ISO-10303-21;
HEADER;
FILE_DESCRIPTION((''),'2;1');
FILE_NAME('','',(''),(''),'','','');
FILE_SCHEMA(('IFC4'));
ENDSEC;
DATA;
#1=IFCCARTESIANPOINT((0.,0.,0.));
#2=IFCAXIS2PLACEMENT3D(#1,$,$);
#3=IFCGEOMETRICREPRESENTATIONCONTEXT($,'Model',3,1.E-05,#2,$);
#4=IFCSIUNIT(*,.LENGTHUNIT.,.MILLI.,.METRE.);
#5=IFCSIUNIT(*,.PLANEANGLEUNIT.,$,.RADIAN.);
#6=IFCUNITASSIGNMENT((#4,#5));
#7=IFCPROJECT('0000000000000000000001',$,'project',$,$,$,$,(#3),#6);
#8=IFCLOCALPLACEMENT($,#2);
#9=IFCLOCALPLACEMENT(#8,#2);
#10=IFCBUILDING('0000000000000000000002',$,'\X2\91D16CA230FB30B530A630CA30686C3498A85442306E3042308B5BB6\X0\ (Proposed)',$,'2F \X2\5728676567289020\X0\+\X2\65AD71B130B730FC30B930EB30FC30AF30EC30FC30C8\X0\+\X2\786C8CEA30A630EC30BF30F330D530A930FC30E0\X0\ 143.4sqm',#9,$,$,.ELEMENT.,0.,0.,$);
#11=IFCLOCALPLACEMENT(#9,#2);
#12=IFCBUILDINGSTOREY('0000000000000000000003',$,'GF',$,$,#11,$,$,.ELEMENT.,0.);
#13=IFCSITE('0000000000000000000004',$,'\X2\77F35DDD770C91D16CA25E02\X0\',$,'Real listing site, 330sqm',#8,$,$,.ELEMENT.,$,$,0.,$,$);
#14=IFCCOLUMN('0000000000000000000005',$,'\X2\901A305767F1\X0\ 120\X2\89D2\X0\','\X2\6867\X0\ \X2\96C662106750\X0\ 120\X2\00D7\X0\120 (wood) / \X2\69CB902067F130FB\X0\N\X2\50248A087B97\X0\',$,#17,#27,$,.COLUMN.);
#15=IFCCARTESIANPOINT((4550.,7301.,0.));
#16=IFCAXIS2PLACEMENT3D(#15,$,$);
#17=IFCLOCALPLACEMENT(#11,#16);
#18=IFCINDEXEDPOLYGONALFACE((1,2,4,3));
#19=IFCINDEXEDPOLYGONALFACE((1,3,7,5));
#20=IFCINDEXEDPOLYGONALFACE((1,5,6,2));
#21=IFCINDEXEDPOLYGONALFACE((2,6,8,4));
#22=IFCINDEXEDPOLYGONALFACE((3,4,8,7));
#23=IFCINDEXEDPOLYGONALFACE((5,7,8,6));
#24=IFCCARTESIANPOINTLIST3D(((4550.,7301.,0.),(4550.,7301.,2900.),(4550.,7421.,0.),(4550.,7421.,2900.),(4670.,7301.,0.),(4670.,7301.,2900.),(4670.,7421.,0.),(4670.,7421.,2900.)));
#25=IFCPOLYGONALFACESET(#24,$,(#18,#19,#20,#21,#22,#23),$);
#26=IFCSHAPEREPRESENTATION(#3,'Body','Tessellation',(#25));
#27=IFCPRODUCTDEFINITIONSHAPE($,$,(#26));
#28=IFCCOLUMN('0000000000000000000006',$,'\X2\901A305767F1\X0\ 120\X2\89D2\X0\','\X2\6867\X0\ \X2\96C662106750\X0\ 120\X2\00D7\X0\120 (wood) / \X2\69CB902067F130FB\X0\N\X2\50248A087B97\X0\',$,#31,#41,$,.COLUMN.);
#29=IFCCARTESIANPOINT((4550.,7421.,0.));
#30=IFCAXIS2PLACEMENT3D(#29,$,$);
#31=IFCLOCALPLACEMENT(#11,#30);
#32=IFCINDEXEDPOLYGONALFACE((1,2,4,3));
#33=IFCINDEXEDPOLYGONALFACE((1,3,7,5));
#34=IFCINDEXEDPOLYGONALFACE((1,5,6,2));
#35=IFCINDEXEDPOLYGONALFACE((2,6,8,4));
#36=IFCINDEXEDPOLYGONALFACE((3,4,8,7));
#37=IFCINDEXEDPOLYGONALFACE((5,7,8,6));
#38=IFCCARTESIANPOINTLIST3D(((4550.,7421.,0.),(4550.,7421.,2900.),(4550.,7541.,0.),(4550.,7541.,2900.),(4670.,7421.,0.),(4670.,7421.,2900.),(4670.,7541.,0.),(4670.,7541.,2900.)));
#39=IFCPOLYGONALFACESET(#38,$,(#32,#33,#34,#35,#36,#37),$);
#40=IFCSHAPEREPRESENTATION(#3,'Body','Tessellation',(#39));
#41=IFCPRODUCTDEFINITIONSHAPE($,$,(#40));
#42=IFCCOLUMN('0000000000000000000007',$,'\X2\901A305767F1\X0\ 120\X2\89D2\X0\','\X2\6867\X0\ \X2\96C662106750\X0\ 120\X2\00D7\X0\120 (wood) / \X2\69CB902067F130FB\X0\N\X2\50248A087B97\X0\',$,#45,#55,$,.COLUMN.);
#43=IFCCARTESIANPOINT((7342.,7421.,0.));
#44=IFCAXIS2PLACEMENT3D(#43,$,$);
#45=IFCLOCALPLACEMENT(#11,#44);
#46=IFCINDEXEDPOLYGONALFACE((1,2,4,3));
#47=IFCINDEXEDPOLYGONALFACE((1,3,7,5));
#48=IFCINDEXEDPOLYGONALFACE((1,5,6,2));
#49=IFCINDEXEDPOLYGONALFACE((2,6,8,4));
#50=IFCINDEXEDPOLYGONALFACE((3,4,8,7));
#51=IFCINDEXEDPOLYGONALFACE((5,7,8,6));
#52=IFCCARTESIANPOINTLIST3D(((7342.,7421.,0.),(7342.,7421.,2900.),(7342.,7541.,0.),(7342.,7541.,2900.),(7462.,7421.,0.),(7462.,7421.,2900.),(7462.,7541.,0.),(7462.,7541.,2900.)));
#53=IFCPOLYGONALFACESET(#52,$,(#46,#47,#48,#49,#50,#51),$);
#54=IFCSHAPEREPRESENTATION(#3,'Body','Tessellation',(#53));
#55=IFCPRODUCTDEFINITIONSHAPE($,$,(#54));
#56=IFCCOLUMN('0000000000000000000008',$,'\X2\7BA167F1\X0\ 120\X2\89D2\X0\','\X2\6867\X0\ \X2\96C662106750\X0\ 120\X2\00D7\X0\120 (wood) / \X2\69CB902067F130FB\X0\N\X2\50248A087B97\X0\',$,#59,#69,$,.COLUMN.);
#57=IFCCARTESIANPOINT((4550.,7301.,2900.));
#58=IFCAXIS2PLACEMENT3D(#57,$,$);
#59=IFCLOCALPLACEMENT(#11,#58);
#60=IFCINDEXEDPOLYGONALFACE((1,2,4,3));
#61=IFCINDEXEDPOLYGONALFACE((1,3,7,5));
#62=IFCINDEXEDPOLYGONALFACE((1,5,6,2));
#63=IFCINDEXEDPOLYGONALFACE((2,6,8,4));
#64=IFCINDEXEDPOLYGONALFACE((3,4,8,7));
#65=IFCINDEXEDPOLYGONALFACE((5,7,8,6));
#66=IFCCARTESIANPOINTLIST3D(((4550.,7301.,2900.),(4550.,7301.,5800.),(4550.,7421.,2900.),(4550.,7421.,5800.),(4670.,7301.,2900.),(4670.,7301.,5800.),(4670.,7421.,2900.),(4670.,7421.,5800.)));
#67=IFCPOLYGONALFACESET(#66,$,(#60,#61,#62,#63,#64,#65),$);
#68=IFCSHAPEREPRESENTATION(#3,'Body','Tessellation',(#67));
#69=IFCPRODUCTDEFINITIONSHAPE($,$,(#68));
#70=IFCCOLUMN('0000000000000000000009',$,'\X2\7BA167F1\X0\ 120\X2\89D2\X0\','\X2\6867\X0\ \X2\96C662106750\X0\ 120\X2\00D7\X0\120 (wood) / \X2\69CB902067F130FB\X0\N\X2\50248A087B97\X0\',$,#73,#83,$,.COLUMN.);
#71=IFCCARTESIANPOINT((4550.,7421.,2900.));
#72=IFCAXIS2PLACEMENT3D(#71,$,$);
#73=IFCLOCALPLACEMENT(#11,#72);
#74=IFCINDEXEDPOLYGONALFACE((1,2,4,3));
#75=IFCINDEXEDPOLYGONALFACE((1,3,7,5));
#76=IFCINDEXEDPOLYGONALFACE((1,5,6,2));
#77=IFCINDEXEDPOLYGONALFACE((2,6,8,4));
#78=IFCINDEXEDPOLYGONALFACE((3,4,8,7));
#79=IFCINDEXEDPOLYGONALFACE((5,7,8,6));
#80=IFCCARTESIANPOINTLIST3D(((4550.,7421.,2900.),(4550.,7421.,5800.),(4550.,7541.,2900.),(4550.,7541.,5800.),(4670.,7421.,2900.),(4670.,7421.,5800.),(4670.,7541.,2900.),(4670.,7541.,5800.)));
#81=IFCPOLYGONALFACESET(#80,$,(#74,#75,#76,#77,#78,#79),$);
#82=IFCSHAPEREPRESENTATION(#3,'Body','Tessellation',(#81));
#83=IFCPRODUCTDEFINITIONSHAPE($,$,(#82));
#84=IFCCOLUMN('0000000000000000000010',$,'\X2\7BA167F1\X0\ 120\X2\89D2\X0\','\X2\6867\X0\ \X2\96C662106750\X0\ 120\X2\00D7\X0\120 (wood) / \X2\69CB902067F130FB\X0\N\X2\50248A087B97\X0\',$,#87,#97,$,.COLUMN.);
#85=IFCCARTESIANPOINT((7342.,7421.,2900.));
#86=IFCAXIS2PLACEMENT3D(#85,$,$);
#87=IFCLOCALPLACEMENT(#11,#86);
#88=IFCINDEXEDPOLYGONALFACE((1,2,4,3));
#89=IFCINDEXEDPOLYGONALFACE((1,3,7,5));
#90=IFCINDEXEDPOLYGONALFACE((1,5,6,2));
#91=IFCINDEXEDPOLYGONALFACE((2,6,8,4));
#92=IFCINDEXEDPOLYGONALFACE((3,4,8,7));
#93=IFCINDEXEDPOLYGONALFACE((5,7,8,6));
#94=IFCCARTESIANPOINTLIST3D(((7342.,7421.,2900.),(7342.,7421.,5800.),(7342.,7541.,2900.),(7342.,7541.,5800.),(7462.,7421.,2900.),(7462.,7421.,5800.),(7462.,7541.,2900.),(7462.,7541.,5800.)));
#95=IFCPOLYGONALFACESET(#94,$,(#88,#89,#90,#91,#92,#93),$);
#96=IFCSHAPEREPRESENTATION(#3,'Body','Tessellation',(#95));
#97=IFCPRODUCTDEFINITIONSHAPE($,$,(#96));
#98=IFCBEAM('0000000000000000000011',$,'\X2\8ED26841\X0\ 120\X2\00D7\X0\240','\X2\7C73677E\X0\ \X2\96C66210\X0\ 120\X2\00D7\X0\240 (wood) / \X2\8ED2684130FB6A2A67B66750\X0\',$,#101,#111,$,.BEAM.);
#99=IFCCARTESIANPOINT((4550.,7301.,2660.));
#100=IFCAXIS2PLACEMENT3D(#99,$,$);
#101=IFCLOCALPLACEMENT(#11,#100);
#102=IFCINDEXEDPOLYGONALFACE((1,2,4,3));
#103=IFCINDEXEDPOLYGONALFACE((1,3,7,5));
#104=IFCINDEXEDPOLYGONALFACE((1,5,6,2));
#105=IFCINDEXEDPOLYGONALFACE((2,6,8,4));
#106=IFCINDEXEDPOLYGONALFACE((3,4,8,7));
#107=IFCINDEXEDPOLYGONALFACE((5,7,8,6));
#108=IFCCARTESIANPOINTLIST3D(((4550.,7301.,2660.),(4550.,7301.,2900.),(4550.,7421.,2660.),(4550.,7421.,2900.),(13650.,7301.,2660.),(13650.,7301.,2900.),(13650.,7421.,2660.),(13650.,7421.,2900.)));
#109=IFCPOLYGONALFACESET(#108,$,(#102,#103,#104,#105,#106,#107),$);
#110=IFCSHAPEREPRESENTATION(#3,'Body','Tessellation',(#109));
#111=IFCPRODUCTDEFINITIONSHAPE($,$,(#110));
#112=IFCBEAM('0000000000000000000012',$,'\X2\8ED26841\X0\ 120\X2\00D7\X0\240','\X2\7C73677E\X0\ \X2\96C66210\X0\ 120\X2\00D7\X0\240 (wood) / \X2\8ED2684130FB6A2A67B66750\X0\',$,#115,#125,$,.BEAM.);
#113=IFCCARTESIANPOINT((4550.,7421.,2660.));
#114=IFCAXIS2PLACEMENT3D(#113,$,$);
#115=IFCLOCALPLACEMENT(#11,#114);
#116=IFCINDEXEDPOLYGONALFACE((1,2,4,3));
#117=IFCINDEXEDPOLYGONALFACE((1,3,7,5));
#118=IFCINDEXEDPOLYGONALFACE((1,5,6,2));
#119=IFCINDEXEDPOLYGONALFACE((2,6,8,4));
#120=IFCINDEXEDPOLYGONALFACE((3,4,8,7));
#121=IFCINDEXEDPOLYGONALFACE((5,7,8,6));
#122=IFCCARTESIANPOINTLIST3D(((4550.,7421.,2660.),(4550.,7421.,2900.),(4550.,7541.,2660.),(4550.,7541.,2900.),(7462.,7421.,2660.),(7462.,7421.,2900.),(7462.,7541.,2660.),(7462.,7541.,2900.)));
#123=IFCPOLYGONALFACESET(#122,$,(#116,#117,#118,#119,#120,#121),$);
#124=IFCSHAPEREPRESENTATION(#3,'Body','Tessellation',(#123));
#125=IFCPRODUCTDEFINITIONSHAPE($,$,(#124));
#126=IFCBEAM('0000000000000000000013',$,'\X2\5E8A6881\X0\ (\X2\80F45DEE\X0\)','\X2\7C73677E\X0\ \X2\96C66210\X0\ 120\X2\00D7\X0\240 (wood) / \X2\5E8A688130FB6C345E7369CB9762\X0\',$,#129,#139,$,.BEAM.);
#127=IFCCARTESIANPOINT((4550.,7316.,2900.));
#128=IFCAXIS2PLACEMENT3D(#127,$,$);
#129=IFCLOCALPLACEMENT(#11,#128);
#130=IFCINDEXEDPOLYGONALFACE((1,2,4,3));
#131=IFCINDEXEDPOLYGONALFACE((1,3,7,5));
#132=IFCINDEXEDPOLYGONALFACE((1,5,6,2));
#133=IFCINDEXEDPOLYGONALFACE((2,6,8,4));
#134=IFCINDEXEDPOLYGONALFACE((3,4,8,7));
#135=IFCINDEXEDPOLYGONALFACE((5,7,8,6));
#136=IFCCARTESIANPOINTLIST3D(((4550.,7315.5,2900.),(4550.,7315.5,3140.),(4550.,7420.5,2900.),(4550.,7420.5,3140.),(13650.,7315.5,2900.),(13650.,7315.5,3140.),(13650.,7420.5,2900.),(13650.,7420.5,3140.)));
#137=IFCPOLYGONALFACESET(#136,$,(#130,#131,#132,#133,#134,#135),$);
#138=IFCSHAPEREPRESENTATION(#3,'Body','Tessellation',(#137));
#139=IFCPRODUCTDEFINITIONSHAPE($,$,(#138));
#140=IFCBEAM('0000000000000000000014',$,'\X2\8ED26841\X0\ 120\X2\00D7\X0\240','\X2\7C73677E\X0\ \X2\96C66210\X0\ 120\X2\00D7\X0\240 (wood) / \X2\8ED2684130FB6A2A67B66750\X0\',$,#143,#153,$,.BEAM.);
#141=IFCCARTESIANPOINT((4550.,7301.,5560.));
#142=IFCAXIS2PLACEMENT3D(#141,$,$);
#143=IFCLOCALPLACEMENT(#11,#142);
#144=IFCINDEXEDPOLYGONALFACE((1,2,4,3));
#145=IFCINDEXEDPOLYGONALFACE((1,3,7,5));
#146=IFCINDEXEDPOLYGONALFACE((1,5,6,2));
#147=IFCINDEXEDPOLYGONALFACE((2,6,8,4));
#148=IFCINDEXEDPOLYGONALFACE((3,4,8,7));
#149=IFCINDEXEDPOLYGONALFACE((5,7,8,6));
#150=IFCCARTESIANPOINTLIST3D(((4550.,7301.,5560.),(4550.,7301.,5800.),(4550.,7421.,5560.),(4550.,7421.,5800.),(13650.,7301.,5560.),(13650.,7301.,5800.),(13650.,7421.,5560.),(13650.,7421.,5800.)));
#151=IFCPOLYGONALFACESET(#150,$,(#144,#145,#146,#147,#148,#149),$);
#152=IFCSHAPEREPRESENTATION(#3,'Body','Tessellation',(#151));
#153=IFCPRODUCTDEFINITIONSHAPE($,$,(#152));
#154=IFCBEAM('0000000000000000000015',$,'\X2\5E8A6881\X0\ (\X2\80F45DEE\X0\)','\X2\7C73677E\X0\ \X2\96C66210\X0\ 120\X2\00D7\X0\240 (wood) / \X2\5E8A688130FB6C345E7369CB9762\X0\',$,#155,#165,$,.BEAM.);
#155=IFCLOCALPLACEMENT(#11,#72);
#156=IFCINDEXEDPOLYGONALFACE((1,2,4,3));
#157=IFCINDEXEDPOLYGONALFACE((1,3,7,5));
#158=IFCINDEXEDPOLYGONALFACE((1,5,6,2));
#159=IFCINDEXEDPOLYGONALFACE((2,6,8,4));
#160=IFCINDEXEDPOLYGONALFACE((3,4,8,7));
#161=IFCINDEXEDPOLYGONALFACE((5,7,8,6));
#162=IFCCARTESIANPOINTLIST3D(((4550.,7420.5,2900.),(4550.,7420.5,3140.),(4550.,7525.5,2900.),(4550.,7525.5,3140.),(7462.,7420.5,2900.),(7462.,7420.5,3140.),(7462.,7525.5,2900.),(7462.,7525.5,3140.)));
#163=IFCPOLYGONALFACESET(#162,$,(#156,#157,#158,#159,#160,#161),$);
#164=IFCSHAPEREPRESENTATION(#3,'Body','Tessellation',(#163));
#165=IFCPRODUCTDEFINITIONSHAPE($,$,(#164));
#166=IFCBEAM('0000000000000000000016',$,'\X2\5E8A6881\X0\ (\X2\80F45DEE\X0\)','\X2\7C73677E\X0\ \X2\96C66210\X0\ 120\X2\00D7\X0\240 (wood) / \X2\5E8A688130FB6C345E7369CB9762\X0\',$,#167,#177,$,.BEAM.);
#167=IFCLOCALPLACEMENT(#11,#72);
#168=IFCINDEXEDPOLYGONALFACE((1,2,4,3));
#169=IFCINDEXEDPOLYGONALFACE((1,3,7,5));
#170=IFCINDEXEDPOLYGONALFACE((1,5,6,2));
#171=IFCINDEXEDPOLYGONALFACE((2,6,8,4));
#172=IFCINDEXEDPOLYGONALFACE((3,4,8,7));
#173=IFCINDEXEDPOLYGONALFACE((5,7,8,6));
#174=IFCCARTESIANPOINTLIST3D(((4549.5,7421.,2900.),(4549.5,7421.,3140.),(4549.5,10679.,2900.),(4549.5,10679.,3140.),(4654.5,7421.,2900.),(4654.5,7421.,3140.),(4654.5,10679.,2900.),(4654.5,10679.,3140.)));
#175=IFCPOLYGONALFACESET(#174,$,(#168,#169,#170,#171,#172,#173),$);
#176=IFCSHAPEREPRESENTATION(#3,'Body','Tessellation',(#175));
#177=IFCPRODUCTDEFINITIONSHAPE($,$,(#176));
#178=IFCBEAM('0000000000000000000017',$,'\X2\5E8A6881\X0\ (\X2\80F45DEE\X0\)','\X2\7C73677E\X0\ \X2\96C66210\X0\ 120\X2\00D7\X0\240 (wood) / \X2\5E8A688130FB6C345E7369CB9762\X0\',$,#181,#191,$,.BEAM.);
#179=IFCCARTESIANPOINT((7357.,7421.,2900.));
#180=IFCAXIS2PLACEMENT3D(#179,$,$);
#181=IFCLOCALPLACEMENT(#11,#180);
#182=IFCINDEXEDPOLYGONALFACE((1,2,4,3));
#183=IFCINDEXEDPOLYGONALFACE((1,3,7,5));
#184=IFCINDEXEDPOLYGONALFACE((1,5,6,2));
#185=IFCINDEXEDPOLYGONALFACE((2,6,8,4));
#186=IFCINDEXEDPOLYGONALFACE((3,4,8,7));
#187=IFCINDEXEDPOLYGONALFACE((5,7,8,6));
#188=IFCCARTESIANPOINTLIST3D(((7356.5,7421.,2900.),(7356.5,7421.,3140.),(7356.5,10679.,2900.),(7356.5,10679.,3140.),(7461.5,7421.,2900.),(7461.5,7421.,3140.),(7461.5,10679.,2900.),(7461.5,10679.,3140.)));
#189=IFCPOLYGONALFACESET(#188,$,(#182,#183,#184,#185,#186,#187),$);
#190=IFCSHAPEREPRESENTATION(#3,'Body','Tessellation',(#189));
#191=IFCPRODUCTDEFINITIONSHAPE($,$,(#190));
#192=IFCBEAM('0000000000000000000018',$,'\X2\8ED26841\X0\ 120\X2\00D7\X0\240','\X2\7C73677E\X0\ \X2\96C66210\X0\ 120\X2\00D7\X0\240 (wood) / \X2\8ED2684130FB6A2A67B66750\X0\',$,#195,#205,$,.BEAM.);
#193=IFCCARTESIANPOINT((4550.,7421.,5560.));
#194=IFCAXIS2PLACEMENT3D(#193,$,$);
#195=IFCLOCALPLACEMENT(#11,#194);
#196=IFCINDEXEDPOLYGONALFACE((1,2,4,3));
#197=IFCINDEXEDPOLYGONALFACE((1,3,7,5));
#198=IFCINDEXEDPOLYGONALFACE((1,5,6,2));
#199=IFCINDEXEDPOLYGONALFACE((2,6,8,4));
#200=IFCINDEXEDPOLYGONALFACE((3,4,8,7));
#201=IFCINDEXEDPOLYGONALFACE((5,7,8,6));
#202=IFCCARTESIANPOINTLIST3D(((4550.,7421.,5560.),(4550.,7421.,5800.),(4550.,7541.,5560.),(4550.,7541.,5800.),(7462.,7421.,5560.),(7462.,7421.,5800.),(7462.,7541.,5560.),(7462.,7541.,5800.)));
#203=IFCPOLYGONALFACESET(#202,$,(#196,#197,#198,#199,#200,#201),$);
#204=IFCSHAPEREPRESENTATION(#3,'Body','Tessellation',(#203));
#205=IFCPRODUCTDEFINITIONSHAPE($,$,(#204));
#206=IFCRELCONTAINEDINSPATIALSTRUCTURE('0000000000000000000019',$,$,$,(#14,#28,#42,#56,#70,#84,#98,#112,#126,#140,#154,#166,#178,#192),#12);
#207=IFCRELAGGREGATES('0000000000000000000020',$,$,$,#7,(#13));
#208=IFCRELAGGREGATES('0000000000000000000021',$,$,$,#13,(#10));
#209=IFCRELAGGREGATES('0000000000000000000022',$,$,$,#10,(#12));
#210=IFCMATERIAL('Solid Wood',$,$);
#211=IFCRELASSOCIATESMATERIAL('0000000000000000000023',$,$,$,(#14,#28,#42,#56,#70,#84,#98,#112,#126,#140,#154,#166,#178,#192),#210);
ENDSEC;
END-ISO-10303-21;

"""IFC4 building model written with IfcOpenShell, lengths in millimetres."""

from ifc_helpers import new_model, si_unit, frame, frame_2d, origin, place, context, project, spatial, rectangle, extrude, material, element, save


model = new_model("IFC4")

# Units and contexts
model_context = context("Model", 3, precision=1e-05, world=origin())
ifc_project = project(units=[si_unit("LENGTHUNIT", "METRE", prefix="MILLI"), si_unit("PLANEANGLEUNIT", "RADIAN")], contexts=[model_context])

# Site, building, storey
site_placement = place(None, origin())
site = spatial("IfcSite", under=ifc_project, at=site_placement, Name="石川県金沢市", ObjectType="Real listing site, 330sqm", CompositionType="ELEMENT", RefElevation=0.0)
building_placement = place(site_placement, origin())
building = spatial("IfcBuilding", under=site, at=building_placement, Name="金沢・サウナと水風呂のある家 (Proposed)", ObjectType="2F 在来木造+断熱シースルークレート+硬質ウレタンフォーム 143.4sqm", CompositionType="ELEMENT", ElevationOfRefHeight=0.0, ElevationOfTerrain=0.0)
storey_placement = place(building_placement, origin())
storey = spatial("IfcBuildingStorey", under=building, at=storey_placement, Name="GF", CompositionType="ELEMENT", Elevation=0.0)

# Columns
ifc_material_1 = material(Name="Solid Wood")
column_1_placement = place(storey_placement, frame((4550.0, 7301.0, 0.0)))
element("IfcColumn", 1, at=column_1_placement, inside=storey, material=ifc_material_1, Name="通し柱 120角", Description="桧 集成材 120×120 (wood) / 構造柱・N値計算", PredefinedType="COLUMN", context=model_context, shape_type="SweptSolid", body=[
    extrude(rectangle(XDim=120.0, YDim=120.0, at=frame_2d((60.0, 60.0))), frame((4550.0, 7301.0, 0.0)), (0.0, 0.0, 1.0), 2900.0),
])
column_2_placement = place(storey_placement, frame((4550.0, 7421.0, 0.0)))
element("IfcColumn", 2, at=column_2_placement, inside=storey, material=ifc_material_1, Name="通し柱 120角", Description="桧 集成材 120×120 (wood) / 構造柱・N値計算", PredefinedType="COLUMN", context=model_context, shape_type="SweptSolid", body=[
    extrude(rectangle(XDim=120.0, YDim=120.0, at=frame_2d((60.0, 60.0))), frame((4550.0, 7421.0, 0.0)), (0.0, 0.0, 1.0), 2900.0),
])
column_3_placement = place(storey_placement, frame((7342.0, 7421.0, 0.0)))
element("IfcColumn", 3, at=column_3_placement, inside=storey, material=ifc_material_1, Name="通し柱 120角", Description="桧 集成材 120×120 (wood) / 構造柱・N値計算", PredefinedType="COLUMN", context=model_context, shape_type="SweptSolid", body=[
    extrude(rectangle(XDim=120.0, YDim=120.0, at=frame_2d((60.0, 60.0))), frame((7342.0, 7421.0, 0.0)), (0.0, 0.0, 1.0), 2900.0),
])
column_4_placement = place(storey_placement, frame((4550.0, 7301.0, 2900.0)))
element("IfcColumn", 4, at=column_4_placement, inside=storey, material=ifc_material_1, Name="管柱 120角", Description="桧 集成材 120×120 (wood) / 構造柱・N値計算", PredefinedType="COLUMN", context=model_context, shape_type="SweptSolid", body=[
    extrude(rectangle(XDim=120.0, YDim=120.0, at=frame_2d((60.0, 60.0))), frame((4550.0, 7301.0, 2900.0)), (0.0, 0.0, 1.0), 2900.0),
])
column_5_placement = place(storey_placement, frame((4550.0, 7421.0, 2900.0)))
element("IfcColumn", 5, at=column_5_placement, inside=storey, material=ifc_material_1, Name="管柱 120角", Description="桧 集成材 120×120 (wood) / 構造柱・N値計算", PredefinedType="COLUMN", context=model_context, shape_type="SweptSolid", body=[
    extrude(rectangle(XDim=120.0, YDim=120.0, at=frame_2d((60.0, 60.0))), frame((4550.0, 7421.0, 2900.0)), (0.0, 0.0, 1.0), 2900.0),
])
column_6_placement = place(storey_placement, frame((7342.0, 7421.0, 2900.0)))
element("IfcColumn", 6, at=column_6_placement, inside=storey, material=ifc_material_1, Name="管柱 120角", Description="桧 集成材 120×120 (wood) / 構造柱・N値計算", PredefinedType="COLUMN", context=model_context, shape_type="SweptSolid", body=[
    extrude(rectangle(XDim=120.0, YDim=120.0, at=frame_2d((60.0, 60.0))), frame((7342.0, 7421.0, 2900.0)), (0.0, 0.0, 1.0), 2900.0),
])

# Beams
beam_1_placement = place(storey_placement, frame((4550.0, 7301.0, 2660.0)))
element("IfcBeam", 7, at=beam_1_placement, inside=storey, material=ifc_material_1, Name="軒桁 120×240", Description="米松 集成 120×240 (wood) / 軒桁・横架材", PredefinedType="BEAM", context=model_context, shape_type="SweptSolid", body=[
    extrude(rectangle(XDim=9100.0, YDim=120.0, at=frame_2d((4550.0, 60.0))), frame((4550.0, 7301.0, 2660.0)), (0.0, 0.0, 1.0), 240.0),
])
beam_2_placement = place(storey_placement, frame((4550.0, 7421.0, 2660.0)))
element("IfcBeam", 8, at=beam_2_placement, inside=storey, material=ifc_material_1, Name="軒桁 120×240", Description="米松 集成 120×240 (wood) / 軒桁・横架材", PredefinedType="BEAM", context=model_context, shape_type="SweptSolid", body=[
    extrude(rectangle(XDim=2912.0, YDim=120.0, at=frame_2d((1456.0, 60.0))), frame((4550.0, 7421.0, 2660.0)), (0.0, 0.0, 1.0), 240.0),
])
beam_3_placement = place(storey_placement, frame((4550.0, 7316.0, 2900.0)))
element("IfcBeam", 9, at=beam_3_placement, inside=storey, material=ifc_material_1, Name="床梁 (胴差)", Description="米松 集成 120×240 (wood) / 床梁・水平構面", PredefinedType="BEAM", context=model_context, shape_type="SweptSolid", body=[
    extrude(rectangle(XDim=9100.0, YDim=105.0, at=frame_2d((4550.0, 52.0))), frame((4550.0, 7316.0, 2900.0)), (0.0, 0.0, 1.0), 240.0),
])
beam_4_placement = place(storey_placement, frame((4550.0, 7301.0, 5560.0)))
element("IfcBeam", 10, at=beam_4_placement, inside=storey, material=ifc_material_1, Name="軒桁 120×240", Description="米松 集成 120×240 (wood) / 軒桁・横架材", PredefinedType="BEAM", context=model_context, shape_type="SweptSolid", body=[
    extrude(rectangle(XDim=9100.0, YDim=120.0, at=frame_2d((4550.0, 60.0))), frame((4550.0, 7301.0, 5560.0)), (0.0, 0.0, 1.0), 240.0),
])
beam_5_placement = place(storey_placement, frame((4550.0, 7421.0, 2900.0)))
element("IfcBeam", 11, at=beam_5_placement, inside=storey, material=ifc_material_1, Name="床梁 (胴差)", Description="米松 集成 120×240 (wood) / 床梁・水平構面", PredefinedType="BEAM", context=model_context, shape_type="SweptSolid", body=[
    extrude(rectangle(XDim=2912.0, YDim=105.0, at=frame_2d((1456.0, 52.0))), frame((4550.0, 7421.0, 2900.0)), (0.0, 0.0, 1.0), 240.0),
])
beam_6_placement = place(storey_placement, frame((4550.0, 7421.0, 2900.0)))
element("IfcBeam", 12, at=beam_6_placement, inside=storey, material=ifc_material_1, Name="床梁 (胴差)", Description="米松 集成 120×240 (wood) / 床梁・水平構面", PredefinedType="BEAM", context=model_context, shape_type="SweptSolid", body=[
    extrude(rectangle(XDim=105.0, YDim=3258.0, at=frame_2d((52.0, 1629.0))), frame((4550.0, 7421.0, 2900.0)), (0.0, 0.0, 1.0), 240.0),
])
beam_7_placement = place(storey_placement, frame((7357.0, 7421.0, 2900.0)))
element("IfcBeam", 13, at=beam_7_placement, inside=storey, material=ifc_material_1, Name="床梁 (胴差)", Description="米松 集成 120×240 (wood) / 床梁・水平構面", PredefinedType="BEAM", context=model_context, shape_type="SweptSolid", body=[
    extrude(rectangle(XDim=105.0, YDim=3258.0, at=frame_2d((52.0, 1629.0))), frame((7357.0, 7421.0, 2900.0)), (0.0, 0.0, 1.0), 240.0),
])
beam_8_placement = place(storey_placement, frame((4550.0, 7421.0, 5560.0)))
element("IfcBeam", 14, at=beam_8_placement, inside=storey, material=ifc_material_1, Name="軒桁 120×240", Description="米松 集成 120×240 (wood) / 軒桁・横架材", PredefinedType="BEAM", context=model_context, shape_type="SweptSolid", body=[
    extrude(rectangle(XDim=2912.0, YDim=120.0, at=frame_2d((1456.0, 60.0))), frame((4550.0, 7421.0, 5560.0)), (0.0, 0.0, 1.0), 240.0),
])

save(model, "model.ifc")
